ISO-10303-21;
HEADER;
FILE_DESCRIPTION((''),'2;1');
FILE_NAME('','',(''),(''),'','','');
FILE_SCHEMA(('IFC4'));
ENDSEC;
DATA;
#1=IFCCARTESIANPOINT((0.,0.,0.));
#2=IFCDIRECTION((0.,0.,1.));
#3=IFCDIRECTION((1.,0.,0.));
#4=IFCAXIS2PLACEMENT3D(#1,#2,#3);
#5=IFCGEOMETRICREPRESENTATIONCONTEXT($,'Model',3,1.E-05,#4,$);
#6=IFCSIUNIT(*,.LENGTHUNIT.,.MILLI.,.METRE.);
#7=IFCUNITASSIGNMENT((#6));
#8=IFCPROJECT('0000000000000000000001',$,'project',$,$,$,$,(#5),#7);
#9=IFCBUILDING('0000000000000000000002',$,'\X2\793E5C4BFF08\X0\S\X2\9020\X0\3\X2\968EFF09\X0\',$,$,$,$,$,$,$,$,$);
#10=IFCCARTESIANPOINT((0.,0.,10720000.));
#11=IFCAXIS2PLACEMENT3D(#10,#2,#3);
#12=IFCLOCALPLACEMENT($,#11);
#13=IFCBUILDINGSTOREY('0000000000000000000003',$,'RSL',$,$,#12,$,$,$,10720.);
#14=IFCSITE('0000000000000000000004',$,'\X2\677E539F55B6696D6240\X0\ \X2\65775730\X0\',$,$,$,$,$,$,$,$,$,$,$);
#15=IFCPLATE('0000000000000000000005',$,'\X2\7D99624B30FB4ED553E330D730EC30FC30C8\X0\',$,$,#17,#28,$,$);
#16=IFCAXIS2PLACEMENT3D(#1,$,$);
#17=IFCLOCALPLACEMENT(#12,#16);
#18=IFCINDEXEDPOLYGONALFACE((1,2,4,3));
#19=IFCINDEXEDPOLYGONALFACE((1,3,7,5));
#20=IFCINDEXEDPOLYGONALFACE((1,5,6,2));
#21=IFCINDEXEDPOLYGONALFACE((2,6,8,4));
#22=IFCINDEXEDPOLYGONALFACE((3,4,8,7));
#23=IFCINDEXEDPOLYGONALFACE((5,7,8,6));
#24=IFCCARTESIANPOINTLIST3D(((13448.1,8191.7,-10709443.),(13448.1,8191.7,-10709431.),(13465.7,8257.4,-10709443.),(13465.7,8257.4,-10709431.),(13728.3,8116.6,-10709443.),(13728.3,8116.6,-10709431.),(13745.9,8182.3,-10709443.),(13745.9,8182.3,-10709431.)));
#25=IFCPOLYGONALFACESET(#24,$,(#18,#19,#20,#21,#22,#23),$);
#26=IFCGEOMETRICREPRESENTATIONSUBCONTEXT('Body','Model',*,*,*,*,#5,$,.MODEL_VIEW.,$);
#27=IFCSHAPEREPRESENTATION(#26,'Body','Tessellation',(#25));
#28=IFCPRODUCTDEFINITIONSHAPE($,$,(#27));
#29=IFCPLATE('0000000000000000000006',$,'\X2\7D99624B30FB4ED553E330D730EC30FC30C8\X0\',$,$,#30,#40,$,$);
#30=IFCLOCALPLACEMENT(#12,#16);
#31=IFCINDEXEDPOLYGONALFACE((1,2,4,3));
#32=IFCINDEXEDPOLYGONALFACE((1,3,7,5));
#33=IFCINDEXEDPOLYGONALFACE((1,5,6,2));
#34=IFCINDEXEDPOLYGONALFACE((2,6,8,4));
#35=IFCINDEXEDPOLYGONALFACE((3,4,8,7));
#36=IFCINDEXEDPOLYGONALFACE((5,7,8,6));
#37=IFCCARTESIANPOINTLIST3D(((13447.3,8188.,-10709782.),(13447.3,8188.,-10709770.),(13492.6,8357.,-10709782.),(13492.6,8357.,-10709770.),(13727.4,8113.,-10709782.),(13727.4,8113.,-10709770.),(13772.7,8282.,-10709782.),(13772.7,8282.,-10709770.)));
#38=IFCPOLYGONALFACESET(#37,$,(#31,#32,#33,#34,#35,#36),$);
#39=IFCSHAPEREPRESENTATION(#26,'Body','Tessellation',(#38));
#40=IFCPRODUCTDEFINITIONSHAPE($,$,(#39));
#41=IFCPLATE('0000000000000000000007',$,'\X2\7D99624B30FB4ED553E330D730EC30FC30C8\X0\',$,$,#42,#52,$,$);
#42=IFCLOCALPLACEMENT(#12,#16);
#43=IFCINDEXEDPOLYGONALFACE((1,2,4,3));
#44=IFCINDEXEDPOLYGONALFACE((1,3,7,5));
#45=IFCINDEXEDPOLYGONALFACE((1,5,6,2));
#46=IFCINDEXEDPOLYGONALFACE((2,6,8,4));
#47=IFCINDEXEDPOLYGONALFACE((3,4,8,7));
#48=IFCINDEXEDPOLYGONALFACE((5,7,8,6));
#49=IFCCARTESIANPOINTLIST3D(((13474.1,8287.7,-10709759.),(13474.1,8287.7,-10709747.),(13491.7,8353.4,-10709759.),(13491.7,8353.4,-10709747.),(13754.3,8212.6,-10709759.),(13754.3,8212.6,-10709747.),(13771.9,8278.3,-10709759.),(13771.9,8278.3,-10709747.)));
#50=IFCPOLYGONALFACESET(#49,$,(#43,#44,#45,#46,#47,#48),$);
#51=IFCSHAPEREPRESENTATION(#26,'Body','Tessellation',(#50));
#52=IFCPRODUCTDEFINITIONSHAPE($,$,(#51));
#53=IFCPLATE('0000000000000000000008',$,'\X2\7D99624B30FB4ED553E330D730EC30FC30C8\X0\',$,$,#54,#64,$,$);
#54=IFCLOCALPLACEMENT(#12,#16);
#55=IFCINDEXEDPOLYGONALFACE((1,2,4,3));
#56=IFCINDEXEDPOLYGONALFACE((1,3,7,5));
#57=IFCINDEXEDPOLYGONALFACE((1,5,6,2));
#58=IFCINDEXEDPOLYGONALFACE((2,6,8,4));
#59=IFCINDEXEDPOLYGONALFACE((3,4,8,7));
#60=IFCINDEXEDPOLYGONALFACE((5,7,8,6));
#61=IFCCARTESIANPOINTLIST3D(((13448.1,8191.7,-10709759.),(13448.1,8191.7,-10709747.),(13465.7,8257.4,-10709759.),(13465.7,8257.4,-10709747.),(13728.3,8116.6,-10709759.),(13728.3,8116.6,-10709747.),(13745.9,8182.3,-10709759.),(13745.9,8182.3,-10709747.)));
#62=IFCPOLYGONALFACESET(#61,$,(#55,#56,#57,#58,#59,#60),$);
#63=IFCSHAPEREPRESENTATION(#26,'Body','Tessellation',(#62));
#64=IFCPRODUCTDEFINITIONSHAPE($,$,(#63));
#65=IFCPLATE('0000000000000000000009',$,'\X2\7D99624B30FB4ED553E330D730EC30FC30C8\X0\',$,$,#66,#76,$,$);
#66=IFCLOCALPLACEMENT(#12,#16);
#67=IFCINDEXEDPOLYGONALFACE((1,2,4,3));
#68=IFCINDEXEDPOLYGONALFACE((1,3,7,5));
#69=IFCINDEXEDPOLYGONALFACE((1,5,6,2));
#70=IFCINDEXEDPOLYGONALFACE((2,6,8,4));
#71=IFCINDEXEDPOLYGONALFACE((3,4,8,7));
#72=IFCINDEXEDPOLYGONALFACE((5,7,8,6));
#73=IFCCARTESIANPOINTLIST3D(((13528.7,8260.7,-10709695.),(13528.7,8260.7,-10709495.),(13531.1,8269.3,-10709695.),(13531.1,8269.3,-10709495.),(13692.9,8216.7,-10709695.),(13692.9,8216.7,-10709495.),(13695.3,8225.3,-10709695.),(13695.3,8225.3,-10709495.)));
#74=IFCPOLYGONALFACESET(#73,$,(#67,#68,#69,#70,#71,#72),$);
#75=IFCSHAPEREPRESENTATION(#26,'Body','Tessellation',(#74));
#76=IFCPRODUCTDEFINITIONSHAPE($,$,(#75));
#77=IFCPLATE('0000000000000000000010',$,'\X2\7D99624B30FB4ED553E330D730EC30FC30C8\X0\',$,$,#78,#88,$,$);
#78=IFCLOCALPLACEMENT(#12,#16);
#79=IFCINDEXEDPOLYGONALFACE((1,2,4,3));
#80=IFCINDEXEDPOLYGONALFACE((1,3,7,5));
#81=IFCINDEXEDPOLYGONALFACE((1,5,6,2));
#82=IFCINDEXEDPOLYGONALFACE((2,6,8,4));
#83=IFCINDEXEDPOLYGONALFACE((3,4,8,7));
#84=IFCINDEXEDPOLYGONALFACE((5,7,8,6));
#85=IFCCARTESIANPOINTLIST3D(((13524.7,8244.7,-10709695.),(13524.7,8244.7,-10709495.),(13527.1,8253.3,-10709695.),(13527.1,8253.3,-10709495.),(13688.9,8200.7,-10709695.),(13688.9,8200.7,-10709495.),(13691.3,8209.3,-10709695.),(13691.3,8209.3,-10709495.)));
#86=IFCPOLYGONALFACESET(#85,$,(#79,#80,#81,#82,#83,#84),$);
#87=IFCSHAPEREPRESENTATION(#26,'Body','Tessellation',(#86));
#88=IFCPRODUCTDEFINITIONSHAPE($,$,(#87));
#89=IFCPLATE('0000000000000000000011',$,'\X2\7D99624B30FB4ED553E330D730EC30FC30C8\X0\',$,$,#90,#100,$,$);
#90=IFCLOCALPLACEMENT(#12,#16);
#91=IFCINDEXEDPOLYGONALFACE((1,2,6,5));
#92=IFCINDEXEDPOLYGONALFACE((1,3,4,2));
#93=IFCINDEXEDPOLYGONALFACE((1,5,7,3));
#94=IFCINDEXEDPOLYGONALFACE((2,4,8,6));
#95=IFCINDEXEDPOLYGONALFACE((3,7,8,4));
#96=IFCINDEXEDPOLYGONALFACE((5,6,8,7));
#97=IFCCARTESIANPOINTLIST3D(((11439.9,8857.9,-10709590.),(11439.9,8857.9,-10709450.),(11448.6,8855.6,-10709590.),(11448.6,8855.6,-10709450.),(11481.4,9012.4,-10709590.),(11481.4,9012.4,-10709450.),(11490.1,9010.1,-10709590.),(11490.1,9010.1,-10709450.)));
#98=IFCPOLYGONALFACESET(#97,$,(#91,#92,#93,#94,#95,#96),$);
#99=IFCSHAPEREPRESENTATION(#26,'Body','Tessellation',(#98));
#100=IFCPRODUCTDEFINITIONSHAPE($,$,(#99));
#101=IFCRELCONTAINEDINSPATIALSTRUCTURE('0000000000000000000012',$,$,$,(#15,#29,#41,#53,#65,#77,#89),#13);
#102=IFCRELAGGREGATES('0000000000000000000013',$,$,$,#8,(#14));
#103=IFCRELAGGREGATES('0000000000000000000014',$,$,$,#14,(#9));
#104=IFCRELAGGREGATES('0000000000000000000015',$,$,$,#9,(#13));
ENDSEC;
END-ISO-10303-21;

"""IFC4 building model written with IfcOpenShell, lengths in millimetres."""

from ifc_helpers import new_model, si_unit, frame, origin, origin_with_axes, place, context, subcontext, project, spatial, rectangle, extrude, element, save


model = new_model("IFC4")

# Units and contexts
model_context = context("Model", 3, precision=1e-05, world=origin_with_axes())
body_context = subcontext(model_context, "Body", "Model", "MODEL_VIEW")
ifc_project = project(units=[si_unit("LENGTHUNIT", "METRE", prefix="MILLI")], contexts=[model_context])

# Site, building, storey
site = spatial("IfcSite", under=ifc_project, Name="松原営業所 敷地")
building = spatial("IfcBuilding", under=site, Name="社屋（S造3階）")
storey_placement = place(None, frame((0.0, 0.0, 10720000.0), z_axis=(0.0, 0.0, 1.0), x_axis=(1.0, 0.0, 0.0)))
storey = spatial("IfcBuildingStorey", under=building, at=storey_placement, Name="RSL", Elevation=10720.0)

# Plates
for number, where, z_axis, x_axis, name in (
    (1, (13456.9, 8224.5, -10709437.0), (0.965926, -0.258819, 0.0), (0.258819, 0.965926, 0.0), "継手・仕口プレート"),
):
    element("IfcPlate", number, at=place(storey_placement, frame(where, z_axis=z_axis, x_axis=x_axis)), inside=storey, Name=name, context=body_context, shape_type="SweptSolid", body=[
        extrude(rectangle(XDim=68.0, YDim=12.0), origin(), (0.0, 0.0, 1.0), 290.0),
    ])
plate_1_placement = place(storey_placement, frame((13469.9, 8272.5, -10709776.0), z_axis=(0.965926, -0.258819, 0.0), x_axis=(0.258819, 0.965926, 0.0)))
element("IfcPlate", 2, at=plate_1_placement, inside=storey, Name="継手・仕口プレート", context=body_context, shape_type="SweptSolid", body=[
    extrude(rectangle(XDim=175.0, YDim=12.0), origin(), (0.0, 0.0, 1.0), 290.0),
])
for number, where, z_axis, x_axis, name in (
    (3, (13482.9, 8320.5, -10709753.0), (0.965926, -0.258819, 0.0), (0.258819, 0.965926, 0.0), "継手・仕口プレート"),
    (4, (13456.9, 8224.5, -10709753.0), (0.965926, -0.258819, 0.0), (0.258819, 0.965926, 0.0), "継手・仕口プレート"),
):
    element("IfcPlate", number, at=place(storey_placement, frame(where, z_axis=z_axis, x_axis=x_axis)), inside=storey, Name=name, context=body_context, shape_type="SweptSolid", body=[
        extrude(rectangle(XDim=68.0, YDim=12.0), origin(), (0.0, 0.0, 1.0), 290.0),
    ])
for number, where, z_axis, x_axis, name in (
    (5, (13529.9, 8265.0, -10709595.0), (0.965926, -0.258819, 0.0), (0.258819, 0.965926, 0.0), "継手・仕口プレート"),
    (6, (13525.9, 8249.0, -10709595.0), (0.965926, -0.258819, 0.0), (0.258819, 0.965926, 0.0), "継手・仕口プレート"),
):
    element("IfcPlate", number, at=place(storey_placement, frame(where, z_axis=z_axis, x_axis=x_axis)), inside=storey, Name=name, context=body_context, shape_type="SweptSolid", body=[
        extrude(rectangle(XDim=9.0, YDim=200.0), origin(), (0.0, 0.0, 1.0), 170.0),
    ])
plate_2_placement = place(storey_placement, frame((11444.3, 8856.7, -10709520.0), z_axis=(0.258819, 0.965926, 0.0), x_axis=(-0.965926, 0.258819, 0.0)))
element("IfcPlate", 7, at=plate_2_placement, inside=storey, Name="継手・仕口プレート", context=body_context, shape_type="SweptSolid", body=[
    extrude(rectangle(XDim=9.0, YDim=140.0), origin(), (0.0, 0.0, 1.0), 160.0),
])

save(model, "model.ifc")
